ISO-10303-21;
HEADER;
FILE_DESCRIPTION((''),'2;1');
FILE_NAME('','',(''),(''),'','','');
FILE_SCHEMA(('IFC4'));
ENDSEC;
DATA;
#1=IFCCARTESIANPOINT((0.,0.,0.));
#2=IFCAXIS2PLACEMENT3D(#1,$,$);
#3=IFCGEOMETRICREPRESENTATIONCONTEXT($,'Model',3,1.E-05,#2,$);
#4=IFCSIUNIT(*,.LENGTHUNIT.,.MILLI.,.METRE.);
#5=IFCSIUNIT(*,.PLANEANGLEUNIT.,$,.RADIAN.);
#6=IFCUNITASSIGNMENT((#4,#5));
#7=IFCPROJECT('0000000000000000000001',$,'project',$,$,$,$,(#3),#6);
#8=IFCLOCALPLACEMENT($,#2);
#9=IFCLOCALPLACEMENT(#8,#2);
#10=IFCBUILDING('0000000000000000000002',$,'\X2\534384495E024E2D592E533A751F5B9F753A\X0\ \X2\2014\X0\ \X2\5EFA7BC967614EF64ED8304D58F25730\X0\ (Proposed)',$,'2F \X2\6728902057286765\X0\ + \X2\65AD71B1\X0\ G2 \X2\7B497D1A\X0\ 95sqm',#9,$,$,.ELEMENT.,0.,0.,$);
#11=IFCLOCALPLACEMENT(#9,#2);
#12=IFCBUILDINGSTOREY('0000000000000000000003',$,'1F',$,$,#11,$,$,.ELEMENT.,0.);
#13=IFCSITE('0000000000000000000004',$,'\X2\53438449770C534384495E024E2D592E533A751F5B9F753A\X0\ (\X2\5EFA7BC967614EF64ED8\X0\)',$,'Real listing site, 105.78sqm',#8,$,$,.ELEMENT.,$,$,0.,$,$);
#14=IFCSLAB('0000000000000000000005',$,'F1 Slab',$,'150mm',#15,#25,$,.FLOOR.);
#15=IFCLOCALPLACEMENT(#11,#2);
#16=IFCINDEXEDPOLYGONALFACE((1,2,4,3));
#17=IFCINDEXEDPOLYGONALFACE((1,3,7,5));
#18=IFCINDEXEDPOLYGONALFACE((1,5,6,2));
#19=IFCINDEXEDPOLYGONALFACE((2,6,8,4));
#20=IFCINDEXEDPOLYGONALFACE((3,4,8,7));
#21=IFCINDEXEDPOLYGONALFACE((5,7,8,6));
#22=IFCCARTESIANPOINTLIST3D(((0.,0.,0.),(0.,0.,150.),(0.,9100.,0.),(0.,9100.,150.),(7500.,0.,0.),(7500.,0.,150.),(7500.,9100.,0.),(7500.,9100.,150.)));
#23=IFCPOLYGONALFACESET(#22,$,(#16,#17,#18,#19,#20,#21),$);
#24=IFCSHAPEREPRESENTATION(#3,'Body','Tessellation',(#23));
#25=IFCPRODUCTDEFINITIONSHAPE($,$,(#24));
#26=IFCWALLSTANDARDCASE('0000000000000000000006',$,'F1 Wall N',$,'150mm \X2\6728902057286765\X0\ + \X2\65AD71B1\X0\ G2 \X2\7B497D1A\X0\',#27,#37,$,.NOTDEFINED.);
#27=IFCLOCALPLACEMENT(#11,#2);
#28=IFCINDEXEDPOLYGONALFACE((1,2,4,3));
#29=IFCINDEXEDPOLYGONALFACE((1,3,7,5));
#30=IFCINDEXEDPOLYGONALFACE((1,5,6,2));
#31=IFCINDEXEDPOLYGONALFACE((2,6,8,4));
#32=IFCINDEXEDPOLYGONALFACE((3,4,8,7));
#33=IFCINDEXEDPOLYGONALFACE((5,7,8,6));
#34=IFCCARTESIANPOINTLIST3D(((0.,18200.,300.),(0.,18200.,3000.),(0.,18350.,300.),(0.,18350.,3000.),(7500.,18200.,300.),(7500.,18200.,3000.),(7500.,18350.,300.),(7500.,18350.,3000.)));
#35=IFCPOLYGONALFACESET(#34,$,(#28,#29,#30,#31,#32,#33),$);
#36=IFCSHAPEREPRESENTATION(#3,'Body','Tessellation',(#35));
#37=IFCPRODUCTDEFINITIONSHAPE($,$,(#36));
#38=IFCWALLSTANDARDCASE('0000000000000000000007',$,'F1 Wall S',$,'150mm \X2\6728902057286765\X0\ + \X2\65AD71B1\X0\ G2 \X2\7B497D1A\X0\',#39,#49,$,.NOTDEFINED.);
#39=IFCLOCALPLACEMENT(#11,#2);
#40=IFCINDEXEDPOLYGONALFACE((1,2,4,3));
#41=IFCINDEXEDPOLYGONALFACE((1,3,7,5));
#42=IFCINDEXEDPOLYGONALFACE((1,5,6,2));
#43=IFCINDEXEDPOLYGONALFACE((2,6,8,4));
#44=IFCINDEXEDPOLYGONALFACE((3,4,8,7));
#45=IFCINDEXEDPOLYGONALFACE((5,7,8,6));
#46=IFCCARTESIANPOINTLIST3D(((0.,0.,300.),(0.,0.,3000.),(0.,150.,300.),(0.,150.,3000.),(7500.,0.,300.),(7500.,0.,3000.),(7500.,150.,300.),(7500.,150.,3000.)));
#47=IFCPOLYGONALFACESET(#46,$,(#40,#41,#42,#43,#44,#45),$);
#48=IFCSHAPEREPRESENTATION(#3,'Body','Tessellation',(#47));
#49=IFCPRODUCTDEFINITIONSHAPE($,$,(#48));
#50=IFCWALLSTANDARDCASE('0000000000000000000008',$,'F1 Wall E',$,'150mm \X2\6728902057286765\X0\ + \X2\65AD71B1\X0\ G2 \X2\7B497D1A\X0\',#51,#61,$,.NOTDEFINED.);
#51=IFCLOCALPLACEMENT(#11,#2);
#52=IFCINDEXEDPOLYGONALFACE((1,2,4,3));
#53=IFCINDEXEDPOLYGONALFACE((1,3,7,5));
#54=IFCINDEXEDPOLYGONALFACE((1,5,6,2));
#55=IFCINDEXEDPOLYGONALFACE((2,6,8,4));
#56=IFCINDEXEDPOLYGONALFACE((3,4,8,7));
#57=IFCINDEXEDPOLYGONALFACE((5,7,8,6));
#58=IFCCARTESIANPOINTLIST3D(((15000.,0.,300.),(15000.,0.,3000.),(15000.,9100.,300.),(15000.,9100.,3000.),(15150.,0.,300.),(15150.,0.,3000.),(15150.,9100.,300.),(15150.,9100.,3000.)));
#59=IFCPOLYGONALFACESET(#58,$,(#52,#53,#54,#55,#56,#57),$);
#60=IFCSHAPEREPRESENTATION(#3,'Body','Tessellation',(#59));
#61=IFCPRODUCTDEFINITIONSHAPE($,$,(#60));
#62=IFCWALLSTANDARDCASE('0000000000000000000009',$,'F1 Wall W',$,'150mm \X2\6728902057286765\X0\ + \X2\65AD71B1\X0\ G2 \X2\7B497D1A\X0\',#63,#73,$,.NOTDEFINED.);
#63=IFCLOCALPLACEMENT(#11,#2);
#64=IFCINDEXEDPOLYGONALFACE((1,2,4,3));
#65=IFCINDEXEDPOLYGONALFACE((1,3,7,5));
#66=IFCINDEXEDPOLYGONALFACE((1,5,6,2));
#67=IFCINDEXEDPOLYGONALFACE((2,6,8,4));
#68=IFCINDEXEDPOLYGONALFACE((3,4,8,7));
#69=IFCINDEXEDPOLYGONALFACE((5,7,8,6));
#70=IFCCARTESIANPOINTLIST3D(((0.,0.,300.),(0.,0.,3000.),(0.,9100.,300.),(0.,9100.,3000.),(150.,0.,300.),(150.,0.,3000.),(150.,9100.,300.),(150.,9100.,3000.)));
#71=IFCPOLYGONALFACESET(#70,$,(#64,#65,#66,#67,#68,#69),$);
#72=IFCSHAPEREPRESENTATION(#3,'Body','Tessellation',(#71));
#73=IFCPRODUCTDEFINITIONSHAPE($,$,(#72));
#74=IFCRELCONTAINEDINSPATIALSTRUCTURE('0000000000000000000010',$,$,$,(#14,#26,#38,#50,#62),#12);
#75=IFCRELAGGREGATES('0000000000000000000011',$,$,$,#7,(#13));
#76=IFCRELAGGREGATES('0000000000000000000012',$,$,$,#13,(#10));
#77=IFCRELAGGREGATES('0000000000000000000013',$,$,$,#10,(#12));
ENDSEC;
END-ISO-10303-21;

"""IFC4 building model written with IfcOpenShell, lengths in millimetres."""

from ifc_helpers import new_model, si_unit, frame, frame_2d, origin, place, context, project, spatial, rectangle, extrude, element, save


model = new_model("IFC4")

# Units and contexts
model_context = context("Model", 3, precision=1e-05, world=origin())
ifc_project = project(units=[si_unit("LENGTHUNIT", "METRE", prefix="MILLI"), si_unit("PLANEANGLEUNIT", "RADIAN")], contexts=[model_context])

# Site, building, storey
site_placement = place(None, origin())
site = spatial("IfcSite", under=ifc_project, at=site_placement, Name="千葉県千葉市中央区生実町 (建築条件付)", ObjectType="Real listing site, 105.78sqm", CompositionType="ELEMENT", RefElevation=0.0)
building_placement = place(site_placement, origin())
building = spatial("IfcBuilding", under=site, at=building_placement, Name="千葉市中央区生実町 — 建築条件付き売地 (Proposed)", ObjectType="2F 木造在来 + 断熱 G2 等級 95sqm", CompositionType="ELEMENT", ElevationOfRefHeight=0.0, ElevationOfTerrain=0.0)
storey_placement = place(building_placement, origin())
storey = spatial("IfcBuildingStorey", under=building, at=storey_placement, Name="1F", CompositionType="ELEMENT", Elevation=0.0)

# Slab
slab_placement = place(storey_placement, origin())
element("IfcSlab", 1, at=slab_placement, inside=storey, Name="F1 Slab", ObjectType="150mm", PredefinedType="FLOOR", context=model_context, shape_type="SweptSolid", body=[
    extrude(rectangle(XDim=7500.0, YDim=9100.0, at=frame_2d((3750.0, 4550.0))), origin(), (0.0, 0.0, 1.0), 150.0),
])

# Walls
wall_1_placement = place(storey_placement, frame((0.0, 9100.0, 150.0)))
element("IfcWallStandardCase", 2, at=wall_1_placement, inside=storey, Name="F1 Wall N", ObjectType="150mm 木造在来 + 断熱 G2 等級", PredefinedType="NOTDEFINED", context=model_context, shape_type="SweptSolid", body=[
    extrude(rectangle(XDim=7500.0, YDim=150.0, at=frame_2d((3750.0, 75.0))), frame((0.0, 9100.0, 150.0)), (0.0, 0.0, 1.0), 2700.0),
])
wall_2_placement = place(storey_placement, frame((0.0, 0.0, 150.0)))
element("IfcWallStandardCase", 3, at=wall_2_placement, inside=storey, Name="F1 Wall S", ObjectType="150mm 木造在来 + 断熱 G2 等級", PredefinedType="NOTDEFINED", context=model_context, shape_type="SweptSolid", body=[
    extrude(rectangle(XDim=7500.0, YDim=150.0, at=frame_2d((3750.0, 75.0))), frame((0.0, 0.0, 150.0)), (0.0, 0.0, 1.0), 2700.0),
])
wall_3_placement = place(storey_placement, frame((7500.0, 0.0, 150.0)))
element("IfcWallStandardCase", 4, at=wall_3_placement, inside=storey, Name="F1 Wall E", ObjectType="150mm 木造在来 + 断熱 G2 等級", PredefinedType="NOTDEFINED", context=model_context, shape_type="SweptSolid", body=[
    extrude(rectangle(XDim=150.0, YDim=9100.0, at=frame_2d((75.0, 4550.0))), frame((7500.0, 0.0, 150.0)), (0.0, 0.0, 1.0), 2700.0),
])
wall_4_placement = place(storey_placement, frame((0.0, 0.0, 150.0)))
element("IfcWallStandardCase", 5, at=wall_4_placement, inside=storey, Name="F1 Wall W", ObjectType="150mm 木造在来 + 断熱 G2 等級", PredefinedType="NOTDEFINED", context=model_context, shape_type="SweptSolid", body=[
    extrude(rectangle(XDim=150.0, YDim=9100.0, at=frame_2d((75.0, 4550.0))), frame((0.0, 0.0, 150.0)), (0.0, 0.0, 1.0), 2700.0),
])

save(model, "model.ifc")
